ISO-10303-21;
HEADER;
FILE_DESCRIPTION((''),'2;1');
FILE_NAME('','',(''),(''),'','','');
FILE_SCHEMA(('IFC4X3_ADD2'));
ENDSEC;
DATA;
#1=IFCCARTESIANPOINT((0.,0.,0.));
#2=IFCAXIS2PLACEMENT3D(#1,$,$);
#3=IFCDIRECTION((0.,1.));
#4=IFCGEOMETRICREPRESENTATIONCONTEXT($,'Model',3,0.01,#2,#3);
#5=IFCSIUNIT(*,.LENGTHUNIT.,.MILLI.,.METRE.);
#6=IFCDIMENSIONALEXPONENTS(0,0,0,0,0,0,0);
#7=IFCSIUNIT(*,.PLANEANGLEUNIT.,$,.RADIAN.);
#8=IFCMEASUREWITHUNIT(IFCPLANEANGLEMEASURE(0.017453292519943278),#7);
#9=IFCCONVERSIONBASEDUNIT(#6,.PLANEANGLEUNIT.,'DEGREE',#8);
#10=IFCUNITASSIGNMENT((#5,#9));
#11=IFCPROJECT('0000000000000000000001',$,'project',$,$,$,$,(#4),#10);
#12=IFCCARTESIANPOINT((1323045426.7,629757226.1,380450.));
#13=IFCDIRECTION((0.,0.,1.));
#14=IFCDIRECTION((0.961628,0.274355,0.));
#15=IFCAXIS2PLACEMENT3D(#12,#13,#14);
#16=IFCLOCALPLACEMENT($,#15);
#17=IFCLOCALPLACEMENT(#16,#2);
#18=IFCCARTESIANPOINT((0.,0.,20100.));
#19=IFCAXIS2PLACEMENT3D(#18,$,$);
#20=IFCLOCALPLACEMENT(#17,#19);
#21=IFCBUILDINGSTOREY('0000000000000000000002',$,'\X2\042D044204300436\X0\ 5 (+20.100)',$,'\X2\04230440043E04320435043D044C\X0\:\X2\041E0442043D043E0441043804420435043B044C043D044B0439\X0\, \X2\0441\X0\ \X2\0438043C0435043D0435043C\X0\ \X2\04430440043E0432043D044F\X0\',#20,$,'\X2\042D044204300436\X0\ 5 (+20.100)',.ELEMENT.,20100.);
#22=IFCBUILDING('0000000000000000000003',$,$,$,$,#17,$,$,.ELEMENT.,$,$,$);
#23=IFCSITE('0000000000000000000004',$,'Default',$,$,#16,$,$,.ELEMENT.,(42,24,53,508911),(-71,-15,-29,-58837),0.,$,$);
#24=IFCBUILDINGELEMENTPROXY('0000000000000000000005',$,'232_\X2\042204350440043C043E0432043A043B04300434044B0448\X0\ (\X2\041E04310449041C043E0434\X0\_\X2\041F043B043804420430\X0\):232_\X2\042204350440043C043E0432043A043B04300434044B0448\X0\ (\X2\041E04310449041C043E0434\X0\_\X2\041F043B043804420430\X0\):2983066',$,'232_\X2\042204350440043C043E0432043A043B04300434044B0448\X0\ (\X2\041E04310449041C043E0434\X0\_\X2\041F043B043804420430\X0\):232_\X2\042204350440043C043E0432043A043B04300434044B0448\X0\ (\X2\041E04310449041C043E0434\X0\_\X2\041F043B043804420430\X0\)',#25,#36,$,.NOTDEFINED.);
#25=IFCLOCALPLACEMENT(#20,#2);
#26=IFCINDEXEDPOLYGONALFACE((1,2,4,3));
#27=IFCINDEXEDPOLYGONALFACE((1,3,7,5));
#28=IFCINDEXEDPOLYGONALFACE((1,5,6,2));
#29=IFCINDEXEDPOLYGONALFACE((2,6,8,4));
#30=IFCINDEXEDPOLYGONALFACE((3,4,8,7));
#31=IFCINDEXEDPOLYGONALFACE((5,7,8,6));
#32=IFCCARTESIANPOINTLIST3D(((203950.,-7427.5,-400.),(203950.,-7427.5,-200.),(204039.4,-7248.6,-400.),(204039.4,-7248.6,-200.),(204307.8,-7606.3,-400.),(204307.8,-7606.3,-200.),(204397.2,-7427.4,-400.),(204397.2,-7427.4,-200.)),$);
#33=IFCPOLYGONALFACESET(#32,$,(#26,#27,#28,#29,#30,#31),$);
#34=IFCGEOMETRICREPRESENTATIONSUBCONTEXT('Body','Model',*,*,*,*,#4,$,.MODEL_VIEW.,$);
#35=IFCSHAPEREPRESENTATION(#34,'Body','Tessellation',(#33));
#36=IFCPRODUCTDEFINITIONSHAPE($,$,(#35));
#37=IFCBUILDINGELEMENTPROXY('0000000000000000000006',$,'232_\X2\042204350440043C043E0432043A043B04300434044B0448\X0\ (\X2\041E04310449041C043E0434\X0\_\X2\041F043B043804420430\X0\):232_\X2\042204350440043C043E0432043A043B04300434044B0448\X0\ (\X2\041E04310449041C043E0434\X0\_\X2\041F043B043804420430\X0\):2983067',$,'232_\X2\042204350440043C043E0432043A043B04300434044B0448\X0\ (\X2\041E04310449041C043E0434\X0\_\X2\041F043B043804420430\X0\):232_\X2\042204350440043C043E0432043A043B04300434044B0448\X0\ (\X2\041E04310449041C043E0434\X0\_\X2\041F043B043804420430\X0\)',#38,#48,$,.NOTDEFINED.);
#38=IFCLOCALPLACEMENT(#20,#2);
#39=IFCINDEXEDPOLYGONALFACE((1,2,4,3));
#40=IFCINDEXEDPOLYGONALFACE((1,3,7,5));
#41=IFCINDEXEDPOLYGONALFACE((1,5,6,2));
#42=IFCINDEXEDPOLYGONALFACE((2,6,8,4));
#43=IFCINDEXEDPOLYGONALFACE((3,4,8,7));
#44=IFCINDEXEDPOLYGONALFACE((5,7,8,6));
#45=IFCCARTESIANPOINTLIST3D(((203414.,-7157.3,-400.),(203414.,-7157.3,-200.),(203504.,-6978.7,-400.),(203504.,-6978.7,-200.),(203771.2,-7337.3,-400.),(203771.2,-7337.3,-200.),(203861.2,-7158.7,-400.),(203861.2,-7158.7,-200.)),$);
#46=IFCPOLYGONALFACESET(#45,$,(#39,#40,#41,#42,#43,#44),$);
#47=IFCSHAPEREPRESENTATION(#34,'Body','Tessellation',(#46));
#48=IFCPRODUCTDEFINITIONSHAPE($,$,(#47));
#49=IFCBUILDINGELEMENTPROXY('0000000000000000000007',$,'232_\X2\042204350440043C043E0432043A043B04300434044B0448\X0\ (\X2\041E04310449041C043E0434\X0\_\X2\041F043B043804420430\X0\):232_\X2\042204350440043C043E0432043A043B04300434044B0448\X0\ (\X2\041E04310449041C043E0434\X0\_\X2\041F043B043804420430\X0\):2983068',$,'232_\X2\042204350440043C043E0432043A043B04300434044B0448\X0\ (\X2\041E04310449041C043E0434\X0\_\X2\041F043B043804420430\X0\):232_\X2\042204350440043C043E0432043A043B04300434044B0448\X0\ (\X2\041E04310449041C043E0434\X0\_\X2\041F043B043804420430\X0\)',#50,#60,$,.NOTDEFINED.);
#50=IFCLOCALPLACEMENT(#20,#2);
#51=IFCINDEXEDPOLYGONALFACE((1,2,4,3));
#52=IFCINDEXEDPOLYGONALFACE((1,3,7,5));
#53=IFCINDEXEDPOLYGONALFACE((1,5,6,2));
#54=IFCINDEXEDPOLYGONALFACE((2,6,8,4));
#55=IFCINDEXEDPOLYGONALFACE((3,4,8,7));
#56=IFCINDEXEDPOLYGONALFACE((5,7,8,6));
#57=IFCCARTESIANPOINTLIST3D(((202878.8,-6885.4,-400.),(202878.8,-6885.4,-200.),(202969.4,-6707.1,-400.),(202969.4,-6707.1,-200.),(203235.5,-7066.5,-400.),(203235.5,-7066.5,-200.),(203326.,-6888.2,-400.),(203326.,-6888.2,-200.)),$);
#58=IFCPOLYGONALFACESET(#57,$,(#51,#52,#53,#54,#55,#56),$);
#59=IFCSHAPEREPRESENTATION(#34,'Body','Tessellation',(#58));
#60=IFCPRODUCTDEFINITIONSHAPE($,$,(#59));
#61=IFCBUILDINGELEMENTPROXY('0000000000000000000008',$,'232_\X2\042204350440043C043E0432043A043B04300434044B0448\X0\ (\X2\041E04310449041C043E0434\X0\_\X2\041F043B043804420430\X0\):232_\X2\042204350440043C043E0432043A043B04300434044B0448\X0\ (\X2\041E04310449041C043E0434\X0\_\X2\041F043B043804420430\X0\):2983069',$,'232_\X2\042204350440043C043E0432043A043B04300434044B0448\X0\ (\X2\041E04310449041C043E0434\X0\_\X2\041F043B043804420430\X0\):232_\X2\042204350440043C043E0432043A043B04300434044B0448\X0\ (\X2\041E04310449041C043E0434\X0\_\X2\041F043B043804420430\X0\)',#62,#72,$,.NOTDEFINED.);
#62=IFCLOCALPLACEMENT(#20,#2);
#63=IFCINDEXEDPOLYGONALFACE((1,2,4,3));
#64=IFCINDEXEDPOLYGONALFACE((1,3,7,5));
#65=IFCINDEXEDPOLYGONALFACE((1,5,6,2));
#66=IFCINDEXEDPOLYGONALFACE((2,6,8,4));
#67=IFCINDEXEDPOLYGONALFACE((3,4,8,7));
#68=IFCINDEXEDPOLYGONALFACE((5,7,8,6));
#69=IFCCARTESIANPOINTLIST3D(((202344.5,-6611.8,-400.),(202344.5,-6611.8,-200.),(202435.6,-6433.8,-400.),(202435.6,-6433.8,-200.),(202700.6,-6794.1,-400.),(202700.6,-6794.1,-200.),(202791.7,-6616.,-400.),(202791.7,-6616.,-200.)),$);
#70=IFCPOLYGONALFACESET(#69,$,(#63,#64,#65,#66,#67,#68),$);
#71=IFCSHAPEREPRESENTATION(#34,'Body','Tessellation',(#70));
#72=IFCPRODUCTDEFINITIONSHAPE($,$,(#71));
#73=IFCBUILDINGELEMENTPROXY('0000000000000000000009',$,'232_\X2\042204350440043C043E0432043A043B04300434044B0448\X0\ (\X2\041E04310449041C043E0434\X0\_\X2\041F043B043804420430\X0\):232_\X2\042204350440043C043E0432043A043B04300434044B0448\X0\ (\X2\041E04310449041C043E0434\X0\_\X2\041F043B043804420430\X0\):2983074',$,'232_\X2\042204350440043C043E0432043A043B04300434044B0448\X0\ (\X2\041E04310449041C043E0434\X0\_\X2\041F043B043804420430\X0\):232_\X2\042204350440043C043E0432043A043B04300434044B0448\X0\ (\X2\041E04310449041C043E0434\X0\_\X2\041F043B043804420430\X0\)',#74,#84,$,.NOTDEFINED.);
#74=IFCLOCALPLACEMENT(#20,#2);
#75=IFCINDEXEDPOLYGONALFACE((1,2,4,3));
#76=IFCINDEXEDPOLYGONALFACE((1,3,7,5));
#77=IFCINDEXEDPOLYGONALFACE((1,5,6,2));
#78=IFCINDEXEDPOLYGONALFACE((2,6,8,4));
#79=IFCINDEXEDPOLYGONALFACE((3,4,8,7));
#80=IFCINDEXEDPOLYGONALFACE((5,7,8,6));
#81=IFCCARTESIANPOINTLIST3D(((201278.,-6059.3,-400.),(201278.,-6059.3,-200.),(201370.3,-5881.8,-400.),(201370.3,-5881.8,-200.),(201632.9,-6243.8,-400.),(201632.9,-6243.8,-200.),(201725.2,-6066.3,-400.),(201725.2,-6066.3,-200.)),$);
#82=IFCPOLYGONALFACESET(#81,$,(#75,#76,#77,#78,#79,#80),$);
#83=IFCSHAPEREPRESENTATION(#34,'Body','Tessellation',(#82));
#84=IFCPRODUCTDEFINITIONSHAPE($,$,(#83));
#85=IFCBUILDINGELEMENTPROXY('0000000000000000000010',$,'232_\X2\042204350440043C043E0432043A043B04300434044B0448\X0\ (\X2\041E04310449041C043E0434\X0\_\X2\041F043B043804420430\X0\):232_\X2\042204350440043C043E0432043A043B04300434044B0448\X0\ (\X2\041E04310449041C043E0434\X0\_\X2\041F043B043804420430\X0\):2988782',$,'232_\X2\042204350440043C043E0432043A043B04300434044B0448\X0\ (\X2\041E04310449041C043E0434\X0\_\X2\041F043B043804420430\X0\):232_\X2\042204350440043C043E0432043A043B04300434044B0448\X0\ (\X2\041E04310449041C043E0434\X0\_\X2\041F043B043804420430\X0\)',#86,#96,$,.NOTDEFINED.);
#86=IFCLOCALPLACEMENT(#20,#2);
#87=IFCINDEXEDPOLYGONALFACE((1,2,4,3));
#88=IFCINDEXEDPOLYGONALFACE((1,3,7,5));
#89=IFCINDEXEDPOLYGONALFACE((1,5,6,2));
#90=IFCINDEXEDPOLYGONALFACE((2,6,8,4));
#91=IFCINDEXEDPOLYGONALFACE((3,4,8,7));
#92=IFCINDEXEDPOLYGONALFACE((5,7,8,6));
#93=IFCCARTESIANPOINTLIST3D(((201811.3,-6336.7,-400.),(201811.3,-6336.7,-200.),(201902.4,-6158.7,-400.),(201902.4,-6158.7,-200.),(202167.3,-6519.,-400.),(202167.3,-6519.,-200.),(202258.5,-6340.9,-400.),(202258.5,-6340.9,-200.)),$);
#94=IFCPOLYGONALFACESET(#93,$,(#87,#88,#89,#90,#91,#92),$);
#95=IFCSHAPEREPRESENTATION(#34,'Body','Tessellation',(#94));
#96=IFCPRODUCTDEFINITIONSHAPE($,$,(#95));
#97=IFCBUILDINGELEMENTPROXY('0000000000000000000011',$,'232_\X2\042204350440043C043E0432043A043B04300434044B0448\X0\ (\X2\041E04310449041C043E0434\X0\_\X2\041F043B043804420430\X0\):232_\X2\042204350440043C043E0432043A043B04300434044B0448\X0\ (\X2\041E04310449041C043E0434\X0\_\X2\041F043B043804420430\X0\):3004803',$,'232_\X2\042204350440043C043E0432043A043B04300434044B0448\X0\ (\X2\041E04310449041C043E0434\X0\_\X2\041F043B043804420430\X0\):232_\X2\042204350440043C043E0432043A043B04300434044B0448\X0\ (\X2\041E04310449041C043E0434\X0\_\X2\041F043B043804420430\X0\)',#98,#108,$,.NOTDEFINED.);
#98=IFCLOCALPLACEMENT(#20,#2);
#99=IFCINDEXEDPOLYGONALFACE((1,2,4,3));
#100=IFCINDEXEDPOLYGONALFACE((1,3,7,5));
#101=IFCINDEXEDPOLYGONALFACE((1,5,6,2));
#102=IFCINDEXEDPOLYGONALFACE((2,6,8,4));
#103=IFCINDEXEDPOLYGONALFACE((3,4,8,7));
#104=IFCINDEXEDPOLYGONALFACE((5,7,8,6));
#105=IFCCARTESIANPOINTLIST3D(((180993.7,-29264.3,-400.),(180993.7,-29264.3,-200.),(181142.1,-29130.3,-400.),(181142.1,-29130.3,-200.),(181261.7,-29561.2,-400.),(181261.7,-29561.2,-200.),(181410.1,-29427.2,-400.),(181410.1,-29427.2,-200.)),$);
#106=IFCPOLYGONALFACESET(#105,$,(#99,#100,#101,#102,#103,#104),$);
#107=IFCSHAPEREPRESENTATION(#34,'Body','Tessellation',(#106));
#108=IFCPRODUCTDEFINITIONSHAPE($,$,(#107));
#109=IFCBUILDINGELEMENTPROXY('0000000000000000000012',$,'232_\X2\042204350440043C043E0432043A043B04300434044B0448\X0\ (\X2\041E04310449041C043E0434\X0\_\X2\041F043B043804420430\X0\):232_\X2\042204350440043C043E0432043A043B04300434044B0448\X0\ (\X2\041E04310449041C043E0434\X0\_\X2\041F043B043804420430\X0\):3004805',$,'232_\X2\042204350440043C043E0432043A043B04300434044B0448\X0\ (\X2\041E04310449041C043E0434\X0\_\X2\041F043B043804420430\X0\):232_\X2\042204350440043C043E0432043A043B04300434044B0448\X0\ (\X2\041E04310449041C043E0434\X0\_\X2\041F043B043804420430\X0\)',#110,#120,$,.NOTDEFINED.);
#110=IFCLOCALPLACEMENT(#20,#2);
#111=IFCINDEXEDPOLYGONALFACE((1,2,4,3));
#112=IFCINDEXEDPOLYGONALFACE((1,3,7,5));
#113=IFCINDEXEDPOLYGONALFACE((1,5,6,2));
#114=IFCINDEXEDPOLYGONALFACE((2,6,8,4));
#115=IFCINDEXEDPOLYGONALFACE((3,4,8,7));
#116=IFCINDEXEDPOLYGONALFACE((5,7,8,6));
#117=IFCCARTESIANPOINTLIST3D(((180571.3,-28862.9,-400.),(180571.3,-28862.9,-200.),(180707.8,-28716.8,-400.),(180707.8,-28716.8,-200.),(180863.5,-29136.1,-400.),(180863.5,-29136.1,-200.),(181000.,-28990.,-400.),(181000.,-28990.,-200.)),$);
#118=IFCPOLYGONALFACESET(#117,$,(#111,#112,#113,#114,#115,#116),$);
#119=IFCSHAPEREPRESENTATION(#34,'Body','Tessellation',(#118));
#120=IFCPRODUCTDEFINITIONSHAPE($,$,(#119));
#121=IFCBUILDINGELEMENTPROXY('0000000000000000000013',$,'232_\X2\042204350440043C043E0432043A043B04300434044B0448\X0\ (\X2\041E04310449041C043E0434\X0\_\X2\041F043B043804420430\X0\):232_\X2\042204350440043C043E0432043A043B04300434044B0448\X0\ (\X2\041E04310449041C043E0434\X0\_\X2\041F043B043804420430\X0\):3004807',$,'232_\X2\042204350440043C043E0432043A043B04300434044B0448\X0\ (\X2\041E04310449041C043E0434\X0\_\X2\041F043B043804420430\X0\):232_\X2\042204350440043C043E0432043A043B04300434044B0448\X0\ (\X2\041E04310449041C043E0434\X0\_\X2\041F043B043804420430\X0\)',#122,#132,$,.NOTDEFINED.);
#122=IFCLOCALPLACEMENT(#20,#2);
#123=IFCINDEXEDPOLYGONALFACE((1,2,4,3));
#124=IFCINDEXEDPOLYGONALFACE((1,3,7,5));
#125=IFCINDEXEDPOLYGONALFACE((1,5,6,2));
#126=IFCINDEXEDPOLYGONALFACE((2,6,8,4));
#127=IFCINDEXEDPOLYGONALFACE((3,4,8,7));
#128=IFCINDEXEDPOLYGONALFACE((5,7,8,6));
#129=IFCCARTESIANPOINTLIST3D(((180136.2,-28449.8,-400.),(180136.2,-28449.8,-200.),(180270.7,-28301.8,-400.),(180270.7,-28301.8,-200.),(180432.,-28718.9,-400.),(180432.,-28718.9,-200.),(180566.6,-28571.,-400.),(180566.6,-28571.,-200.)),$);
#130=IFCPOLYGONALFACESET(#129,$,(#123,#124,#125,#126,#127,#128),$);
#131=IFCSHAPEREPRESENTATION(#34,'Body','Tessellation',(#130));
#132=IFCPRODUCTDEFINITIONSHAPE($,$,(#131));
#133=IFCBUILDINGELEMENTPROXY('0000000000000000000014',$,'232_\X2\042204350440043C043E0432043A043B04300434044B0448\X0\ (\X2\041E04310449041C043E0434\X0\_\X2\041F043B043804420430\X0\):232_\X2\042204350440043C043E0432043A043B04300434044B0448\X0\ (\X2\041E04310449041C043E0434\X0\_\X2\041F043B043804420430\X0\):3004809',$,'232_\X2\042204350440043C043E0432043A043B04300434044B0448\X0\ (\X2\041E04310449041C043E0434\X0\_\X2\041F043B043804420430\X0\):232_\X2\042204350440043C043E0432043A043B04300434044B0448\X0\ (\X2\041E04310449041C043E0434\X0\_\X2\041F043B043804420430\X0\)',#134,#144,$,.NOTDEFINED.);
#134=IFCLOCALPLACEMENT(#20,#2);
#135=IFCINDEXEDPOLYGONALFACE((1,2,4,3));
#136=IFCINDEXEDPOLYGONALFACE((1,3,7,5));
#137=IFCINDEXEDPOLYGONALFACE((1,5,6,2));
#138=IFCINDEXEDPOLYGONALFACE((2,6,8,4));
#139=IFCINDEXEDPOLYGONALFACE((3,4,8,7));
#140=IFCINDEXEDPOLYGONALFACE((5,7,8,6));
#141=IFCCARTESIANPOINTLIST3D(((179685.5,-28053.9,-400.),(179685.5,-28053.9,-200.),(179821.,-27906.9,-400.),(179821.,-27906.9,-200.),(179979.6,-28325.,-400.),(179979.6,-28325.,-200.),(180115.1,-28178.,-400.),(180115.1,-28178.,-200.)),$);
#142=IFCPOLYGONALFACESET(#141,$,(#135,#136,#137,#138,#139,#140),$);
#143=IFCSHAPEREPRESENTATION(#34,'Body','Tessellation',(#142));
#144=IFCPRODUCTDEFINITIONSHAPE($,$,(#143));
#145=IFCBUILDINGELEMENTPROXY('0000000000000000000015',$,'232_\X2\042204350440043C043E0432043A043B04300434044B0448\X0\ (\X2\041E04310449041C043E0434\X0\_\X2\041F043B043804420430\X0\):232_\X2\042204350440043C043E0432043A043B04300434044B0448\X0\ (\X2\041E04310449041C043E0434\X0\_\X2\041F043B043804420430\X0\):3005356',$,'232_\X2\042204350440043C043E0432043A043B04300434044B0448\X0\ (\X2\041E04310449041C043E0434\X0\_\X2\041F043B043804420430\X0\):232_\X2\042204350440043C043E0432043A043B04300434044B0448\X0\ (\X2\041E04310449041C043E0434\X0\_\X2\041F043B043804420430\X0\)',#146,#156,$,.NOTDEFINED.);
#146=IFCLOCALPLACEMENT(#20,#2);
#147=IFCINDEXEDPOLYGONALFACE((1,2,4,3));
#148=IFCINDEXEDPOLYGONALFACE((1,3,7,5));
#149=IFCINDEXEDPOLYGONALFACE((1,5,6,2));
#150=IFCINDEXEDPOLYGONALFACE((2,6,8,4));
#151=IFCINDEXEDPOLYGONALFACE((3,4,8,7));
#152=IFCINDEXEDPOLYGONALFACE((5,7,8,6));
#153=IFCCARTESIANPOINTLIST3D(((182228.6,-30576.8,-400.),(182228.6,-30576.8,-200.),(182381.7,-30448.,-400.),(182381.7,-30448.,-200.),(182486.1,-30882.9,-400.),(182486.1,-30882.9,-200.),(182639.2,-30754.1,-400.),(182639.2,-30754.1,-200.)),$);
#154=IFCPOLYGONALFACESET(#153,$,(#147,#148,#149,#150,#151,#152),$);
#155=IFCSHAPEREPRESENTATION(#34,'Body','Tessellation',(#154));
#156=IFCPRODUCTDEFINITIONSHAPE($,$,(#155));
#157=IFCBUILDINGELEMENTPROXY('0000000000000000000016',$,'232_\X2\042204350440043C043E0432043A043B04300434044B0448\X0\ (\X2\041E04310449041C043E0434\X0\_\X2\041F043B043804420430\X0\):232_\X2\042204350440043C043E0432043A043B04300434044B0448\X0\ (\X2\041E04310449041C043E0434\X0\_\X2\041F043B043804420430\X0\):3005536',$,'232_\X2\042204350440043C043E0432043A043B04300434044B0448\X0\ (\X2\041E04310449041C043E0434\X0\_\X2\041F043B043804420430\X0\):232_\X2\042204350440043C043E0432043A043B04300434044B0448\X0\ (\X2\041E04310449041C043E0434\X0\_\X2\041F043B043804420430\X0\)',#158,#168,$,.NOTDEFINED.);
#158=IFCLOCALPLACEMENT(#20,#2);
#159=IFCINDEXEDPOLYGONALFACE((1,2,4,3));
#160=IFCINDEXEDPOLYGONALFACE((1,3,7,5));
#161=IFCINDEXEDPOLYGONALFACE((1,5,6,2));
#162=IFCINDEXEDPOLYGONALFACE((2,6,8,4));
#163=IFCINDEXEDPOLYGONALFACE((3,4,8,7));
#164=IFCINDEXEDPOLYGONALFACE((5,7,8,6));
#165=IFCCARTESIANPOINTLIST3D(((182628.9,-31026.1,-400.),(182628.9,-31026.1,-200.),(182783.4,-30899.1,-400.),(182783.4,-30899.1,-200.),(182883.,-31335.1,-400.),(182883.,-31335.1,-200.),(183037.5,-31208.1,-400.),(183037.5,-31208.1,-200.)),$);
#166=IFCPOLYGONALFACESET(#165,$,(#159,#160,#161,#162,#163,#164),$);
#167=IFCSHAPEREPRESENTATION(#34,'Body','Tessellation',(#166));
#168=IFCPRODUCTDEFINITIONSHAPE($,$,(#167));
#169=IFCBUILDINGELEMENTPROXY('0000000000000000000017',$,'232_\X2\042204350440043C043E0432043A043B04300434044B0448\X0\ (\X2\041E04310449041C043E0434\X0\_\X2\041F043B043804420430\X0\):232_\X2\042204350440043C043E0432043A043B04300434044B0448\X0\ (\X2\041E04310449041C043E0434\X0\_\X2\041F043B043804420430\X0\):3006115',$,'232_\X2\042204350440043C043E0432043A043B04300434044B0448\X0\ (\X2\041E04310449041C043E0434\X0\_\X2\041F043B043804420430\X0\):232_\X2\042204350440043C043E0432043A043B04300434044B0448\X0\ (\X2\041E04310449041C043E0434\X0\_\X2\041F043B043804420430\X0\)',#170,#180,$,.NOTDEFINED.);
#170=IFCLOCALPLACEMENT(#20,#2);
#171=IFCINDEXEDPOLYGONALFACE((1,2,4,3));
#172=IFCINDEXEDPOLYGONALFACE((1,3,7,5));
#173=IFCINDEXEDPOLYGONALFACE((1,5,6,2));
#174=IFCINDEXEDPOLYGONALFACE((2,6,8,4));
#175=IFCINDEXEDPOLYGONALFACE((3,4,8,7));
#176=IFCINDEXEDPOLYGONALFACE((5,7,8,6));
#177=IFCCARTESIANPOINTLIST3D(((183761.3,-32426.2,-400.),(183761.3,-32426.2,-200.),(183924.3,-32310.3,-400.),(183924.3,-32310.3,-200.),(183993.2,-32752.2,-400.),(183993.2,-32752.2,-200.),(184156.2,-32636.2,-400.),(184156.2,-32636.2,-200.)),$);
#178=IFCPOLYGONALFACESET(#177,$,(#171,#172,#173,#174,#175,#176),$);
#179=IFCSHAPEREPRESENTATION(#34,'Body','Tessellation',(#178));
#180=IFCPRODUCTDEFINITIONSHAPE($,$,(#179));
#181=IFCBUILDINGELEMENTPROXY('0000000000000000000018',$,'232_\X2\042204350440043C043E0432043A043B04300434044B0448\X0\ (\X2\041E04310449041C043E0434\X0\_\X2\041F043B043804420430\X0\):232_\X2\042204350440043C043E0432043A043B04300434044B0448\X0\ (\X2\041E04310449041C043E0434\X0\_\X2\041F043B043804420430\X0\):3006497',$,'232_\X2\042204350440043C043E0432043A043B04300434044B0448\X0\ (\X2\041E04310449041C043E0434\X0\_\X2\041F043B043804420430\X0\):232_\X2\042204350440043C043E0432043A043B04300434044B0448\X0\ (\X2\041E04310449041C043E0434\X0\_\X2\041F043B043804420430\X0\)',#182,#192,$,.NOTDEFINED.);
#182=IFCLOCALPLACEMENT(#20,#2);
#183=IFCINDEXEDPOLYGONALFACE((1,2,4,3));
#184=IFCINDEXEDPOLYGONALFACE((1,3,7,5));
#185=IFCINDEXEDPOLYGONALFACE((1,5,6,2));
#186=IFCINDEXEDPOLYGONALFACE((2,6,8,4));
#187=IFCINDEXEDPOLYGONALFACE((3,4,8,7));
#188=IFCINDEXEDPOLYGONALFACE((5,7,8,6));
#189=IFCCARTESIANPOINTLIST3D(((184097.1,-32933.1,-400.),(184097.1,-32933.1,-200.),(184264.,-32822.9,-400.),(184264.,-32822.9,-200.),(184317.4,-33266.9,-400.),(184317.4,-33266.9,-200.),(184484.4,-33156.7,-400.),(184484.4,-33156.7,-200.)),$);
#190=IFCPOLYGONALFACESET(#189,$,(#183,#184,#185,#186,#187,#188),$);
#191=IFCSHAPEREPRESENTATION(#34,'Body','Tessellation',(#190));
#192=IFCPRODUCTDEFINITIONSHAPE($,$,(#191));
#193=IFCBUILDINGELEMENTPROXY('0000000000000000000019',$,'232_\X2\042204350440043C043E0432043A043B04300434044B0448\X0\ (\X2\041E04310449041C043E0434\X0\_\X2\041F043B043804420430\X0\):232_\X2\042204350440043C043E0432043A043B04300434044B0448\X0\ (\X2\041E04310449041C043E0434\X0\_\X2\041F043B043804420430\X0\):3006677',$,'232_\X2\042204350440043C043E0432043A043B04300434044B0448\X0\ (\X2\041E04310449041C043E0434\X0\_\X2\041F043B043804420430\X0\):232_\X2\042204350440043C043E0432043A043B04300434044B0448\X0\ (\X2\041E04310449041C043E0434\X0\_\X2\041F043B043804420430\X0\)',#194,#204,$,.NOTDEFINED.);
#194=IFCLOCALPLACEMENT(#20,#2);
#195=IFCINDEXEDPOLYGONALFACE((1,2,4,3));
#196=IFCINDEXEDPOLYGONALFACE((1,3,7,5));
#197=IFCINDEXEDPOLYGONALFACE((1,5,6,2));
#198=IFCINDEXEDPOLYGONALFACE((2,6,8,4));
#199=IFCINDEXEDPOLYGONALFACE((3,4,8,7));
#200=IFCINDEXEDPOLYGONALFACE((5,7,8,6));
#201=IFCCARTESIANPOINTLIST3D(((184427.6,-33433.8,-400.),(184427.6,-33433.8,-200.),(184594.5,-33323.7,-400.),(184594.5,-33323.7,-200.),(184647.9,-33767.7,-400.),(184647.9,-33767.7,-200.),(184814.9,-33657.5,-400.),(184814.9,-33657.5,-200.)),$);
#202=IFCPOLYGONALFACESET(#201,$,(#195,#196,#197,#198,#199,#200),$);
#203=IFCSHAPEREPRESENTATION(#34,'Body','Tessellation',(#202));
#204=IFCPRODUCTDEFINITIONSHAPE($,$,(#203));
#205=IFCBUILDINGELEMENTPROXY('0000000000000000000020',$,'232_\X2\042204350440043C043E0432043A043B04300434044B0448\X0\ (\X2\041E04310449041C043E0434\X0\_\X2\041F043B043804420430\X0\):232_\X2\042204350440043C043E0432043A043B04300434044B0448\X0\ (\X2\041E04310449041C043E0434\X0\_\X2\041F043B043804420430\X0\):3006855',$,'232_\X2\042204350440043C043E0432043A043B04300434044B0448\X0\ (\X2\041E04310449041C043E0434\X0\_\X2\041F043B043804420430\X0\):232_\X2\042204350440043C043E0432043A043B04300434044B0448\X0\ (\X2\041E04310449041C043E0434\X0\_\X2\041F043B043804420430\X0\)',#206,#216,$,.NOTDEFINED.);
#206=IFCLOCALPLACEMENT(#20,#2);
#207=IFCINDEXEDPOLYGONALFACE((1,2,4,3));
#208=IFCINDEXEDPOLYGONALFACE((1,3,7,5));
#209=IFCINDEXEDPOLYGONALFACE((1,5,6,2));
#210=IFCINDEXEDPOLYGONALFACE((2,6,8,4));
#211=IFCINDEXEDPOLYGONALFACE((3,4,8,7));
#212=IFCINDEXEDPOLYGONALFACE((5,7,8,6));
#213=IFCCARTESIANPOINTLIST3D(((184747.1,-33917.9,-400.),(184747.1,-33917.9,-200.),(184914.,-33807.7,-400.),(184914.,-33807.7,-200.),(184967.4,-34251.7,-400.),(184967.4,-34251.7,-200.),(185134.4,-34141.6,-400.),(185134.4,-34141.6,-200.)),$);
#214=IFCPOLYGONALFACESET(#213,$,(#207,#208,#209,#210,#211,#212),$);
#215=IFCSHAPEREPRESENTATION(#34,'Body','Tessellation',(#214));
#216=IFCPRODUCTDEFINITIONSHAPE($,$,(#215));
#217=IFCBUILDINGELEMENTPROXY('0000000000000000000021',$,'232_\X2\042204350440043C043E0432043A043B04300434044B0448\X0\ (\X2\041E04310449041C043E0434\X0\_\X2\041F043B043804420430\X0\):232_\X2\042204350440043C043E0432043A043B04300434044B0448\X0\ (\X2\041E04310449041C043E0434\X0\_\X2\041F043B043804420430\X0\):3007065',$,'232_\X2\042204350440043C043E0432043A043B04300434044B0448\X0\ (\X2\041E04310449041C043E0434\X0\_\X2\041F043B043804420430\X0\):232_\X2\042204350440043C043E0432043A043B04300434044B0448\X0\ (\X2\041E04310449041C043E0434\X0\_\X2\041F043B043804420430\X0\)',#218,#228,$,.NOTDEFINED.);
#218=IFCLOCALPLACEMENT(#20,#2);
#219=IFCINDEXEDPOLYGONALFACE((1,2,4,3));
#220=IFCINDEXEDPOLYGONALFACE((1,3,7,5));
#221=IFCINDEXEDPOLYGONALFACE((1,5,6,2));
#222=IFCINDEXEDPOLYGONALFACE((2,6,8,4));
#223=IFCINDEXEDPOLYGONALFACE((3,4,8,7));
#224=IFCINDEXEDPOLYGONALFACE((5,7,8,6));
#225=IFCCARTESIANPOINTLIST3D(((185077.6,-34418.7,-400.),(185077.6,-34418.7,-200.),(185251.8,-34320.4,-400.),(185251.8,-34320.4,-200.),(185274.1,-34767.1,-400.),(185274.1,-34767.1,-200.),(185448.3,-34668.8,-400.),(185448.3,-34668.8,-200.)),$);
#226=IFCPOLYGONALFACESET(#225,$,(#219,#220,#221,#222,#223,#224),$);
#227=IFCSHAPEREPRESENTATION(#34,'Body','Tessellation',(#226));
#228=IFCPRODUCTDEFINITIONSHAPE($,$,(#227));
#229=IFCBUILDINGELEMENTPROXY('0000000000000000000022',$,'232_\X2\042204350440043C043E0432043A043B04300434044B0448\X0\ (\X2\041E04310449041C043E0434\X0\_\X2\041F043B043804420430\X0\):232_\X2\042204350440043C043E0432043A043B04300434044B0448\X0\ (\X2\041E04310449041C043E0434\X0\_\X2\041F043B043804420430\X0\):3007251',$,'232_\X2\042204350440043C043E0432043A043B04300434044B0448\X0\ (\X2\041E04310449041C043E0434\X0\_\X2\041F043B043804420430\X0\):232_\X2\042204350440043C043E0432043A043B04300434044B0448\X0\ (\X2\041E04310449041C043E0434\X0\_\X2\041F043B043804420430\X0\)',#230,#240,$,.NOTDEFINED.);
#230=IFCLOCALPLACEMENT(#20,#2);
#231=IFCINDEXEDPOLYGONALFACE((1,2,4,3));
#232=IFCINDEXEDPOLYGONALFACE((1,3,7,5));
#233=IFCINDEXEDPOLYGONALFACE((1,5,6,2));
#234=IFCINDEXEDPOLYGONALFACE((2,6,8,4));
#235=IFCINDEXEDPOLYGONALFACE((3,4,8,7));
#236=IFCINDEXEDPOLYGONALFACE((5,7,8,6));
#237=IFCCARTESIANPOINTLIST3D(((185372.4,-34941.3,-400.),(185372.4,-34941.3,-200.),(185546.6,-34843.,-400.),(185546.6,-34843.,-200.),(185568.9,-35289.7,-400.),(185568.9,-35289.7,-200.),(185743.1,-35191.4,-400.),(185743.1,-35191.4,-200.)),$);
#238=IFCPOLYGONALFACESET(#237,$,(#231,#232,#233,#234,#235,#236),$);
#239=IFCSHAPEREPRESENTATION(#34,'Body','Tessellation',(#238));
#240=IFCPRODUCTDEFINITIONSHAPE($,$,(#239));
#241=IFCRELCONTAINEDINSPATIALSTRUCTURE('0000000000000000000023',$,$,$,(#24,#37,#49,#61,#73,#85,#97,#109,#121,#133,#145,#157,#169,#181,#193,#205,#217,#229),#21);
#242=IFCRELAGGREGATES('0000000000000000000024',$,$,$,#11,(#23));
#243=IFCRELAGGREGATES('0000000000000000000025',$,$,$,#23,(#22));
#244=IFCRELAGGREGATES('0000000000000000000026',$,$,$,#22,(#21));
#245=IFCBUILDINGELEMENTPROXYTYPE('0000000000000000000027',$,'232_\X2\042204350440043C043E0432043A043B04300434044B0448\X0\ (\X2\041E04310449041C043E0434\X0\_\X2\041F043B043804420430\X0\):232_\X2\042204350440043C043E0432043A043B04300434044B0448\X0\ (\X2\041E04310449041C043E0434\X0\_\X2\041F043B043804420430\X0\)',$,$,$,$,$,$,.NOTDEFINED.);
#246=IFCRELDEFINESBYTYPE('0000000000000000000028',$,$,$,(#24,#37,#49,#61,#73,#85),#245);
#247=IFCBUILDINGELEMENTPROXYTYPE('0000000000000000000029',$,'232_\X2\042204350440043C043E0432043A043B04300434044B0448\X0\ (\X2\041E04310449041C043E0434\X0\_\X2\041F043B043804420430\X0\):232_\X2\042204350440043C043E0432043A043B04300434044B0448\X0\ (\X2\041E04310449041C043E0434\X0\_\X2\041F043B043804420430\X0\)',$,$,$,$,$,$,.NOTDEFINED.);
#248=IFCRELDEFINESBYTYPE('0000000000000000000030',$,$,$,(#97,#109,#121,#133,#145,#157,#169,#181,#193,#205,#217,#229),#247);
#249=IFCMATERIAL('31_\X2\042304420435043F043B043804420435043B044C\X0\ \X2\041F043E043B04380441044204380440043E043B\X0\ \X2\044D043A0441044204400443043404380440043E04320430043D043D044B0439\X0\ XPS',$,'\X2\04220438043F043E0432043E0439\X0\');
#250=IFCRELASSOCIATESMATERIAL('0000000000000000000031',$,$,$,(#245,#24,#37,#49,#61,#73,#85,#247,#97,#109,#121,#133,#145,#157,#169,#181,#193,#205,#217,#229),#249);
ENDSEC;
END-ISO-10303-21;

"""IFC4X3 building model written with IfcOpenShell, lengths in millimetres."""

from ifc_helpers import new_model, entity, si_unit, converted_unit, direction, frame, origin, origin_2d_with_axis, place, context, subcontext, project, spatial, rectangle, extrude, source, transform, mapped, material, type_object, type_shapes, element, save


model = new_model("IFC4X3")

# Units and contexts
model_context = context("Model", 3, precision=0.01, world=origin(), true_north=direction((0.0, 1.0)))
body_context = subcontext(model_context, "Body", "Model", "MODEL_VIEW")
ifc_project = project(units=[si_unit("LENGTHUNIT", "METRE", prefix="MILLI"), converted_unit("PLANEANGLEUNIT", "DEGREE", entity("IfcPlaneAngleMeasure", 0.017453292519943278), si_unit("PLANEANGLEUNIT", "RADIAN"), dimensions=[0, 0, 0, 0, 0, 0, 0])], contexts=[model_context])

# Site, building, storey
site_placement = place(None, frame((1323045426.7, 629757226.1, 380450.0), z_axis=(0.0, 0.0, 1.0), x_axis=(0.961628, 0.274355, 0.0)))
site = spatial("IfcSite", under=ifc_project, at=site_placement, Name="Default", CompositionType="ELEMENT", RefLatitude=(42, 24, 53, 508911), RefLongitude=(-71, -15, -29, -58837), RefElevation=0.0)
building_placement = place(site_placement, origin())
building = spatial("IfcBuilding", under=site, at=building_placement, CompositionType="ELEMENT")
storey_placement = place(building_placement, frame((0.0, 0.0, 20100.0)))
storey = spatial("IfcBuildingStorey", under=building, at=storey_placement, Name="Этаж 5 (+20.100)", ObjectType="Уровень:Относительный, с именем уровня", LongName="Этаж 5 (+20.100)", CompositionType="ELEMENT", Elevation=20100.0)

# Building element proxies
ifc_material = material(Name="31_Утеплитель Полистирол экструдированный XPS", Category="Типовой")
building_element_proxy_type_1 = type_object("IfcBuildingElementProxyType", Name="232_Термовкладыш (ОбщМод_Плита):232_Термовкладыш (ОбщМод_Плита)", PredefinedType="NOTDEFINED", material=ifc_material)
shared_shape_1 = source(origin(), body_context, "Body", "SweptSolid", [
    extrude(rectangle(XDim=400.0, YDim=200.0, at=origin_2d_with_axis()), frame((200.0, 0.0, -200.0), z_axis=(0.0, 0.0, 1.0), x_axis=(-1.0, 0.0, 0.0)), (0.0, 0.0, 1.0), 200.0),
])
type_shapes(building_element_proxy_type_1, [shared_shape_1])
for number, where, z_axis, x_axis, name in (
    (1, (204352.5, -7516.9, -200.0), (0.0, 0.0, 1.0), (-0.894486, 0.447096, 0.0), "232_Термовкладыш (ОбщМод_Плита):232_Термовкладыш (ОбщМод_Плита):2983066"),
    (2, (203816.2, -7248.0, -200.0), (0.0, 0.0, 1.0), (-0.893056, 0.449945, 0.0), "232_Термовкладыш (ОбщМод_Плита):232_Термовкладыш (ОбщМод_Плита):2983067"),
    (3, (203280.7, -6977.4, -200.0), (0.0, 0.0, 1.0), (-0.891618, 0.452789, 0.0), "232_Термовкладыш (ОбщМод_Плита):232_Термовкладыш (ОбщМод_Плита):2983068"),
    (4, (202746.1, -6705.0, -200.0), (0.0, 0.0, 1.0), (-0.89017, 0.455629, 0.0), "232_Термовкладыш (ОбщМод_Плита):232_Термовкладыш (ОбщМод_Плита):2983069"),
    (5, (201679.1, -6155.1, -200.0), (0.0, 0.0, 1.0), (-0.887248, 0.461294, 0.0), "232_Термовкладыш (ОбщМод_Плита):232_Термовкладыш (ОбщМод_Плита):2983074"),
    (6, (202212.9, -6430.0, -200.0), (0.0, 0.0, 1.0), (-0.89017, 0.455629, 0.0), "232_Термовкладыш (ОбщМод_Плита):232_Термовкладыш (ОбщМод_Плита):2988782"),
):
    element("IfcBuildingElementProxy", number, at=place(storey_placement, frame(where, z_axis=z_axis, x_axis=x_axis)), inside=storey, type_object=building_element_proxy_type_1, material=ifc_material, Name=name, ObjectType="232_Термовкладыш (ОбщМод_Плита):232_Термовкладыш (ОбщМод_Плита)", PredefinedType="NOTDEFINED", context=body_context, shape_type="MappedRepresentation", body=[
        mapped(shared_shape_1, transform((0.0, 0.0, 0.0), scale=1.0)),
    ])
building_element_proxy_type_2 = type_object("IfcBuildingElementProxyType", Name="232_Термовкладыш (ОбщМод_Плита):232_Термовкладыш (ОбщМод_Плита)", PredefinedType="NOTDEFINED", material=ifc_material)
shared_shape_2 = source(origin(), body_context, "Body", "SweptSolid", [
    extrude(rectangle(XDim=200.0, YDim=400.0, at=origin_2d_with_axis()), frame((200.0, 0.0, -200.0), z_axis=(0.0, 0.0, 1.0), x_axis=(0.0, 1.0, 0.0)), (0.0, 0.0, 1.0), 200.0),
])
type_shapes(building_element_proxy_type_2, [shared_shape_2])
for number, where, z_axis, x_axis, name in (
    (7, (181335.9, -29494.2, -200.0), (0.0, 0.0, 1.0), (-0.67003, 0.742334, 0.0), "232_Термовкладыш (ОбщМод_Плита):232_Термовкладыш (ОбщМод_Плита):3004803"),
    (8, (180931.7, -29063.0, -200.0), (0.0, 0.0, 1.0), (-0.730486, 0.682927, 0.0), "232_Термовкладыш (ОбщМод_Плита):232_Термовкладыш (ОбщМод_Плита):3004805"),
    (9, (180499.3, -28645.0, -200.0), (0.0, 0.0, 1.0), (-0.739744, 0.672889, 0.0), "232_Термовкладыш (ОбщМод_Плита):232_Термовкладыш (ОбщМод_Плита):3004807"),
    (10, (180047.4, -28251.5, -200.0), (0.0, 0.0, 1.0), (-0.735295, 0.677747, 0.0), "232_Термовкладыш (ОбщМод_Плита):232_Термовкладыш (ОбщМод_Плита):3004809"),
    (11, (182562.6, -30818.5, -200.0), (0.0, 0.0, 1.0), (-0.643715, 0.765265, 0.0), "232_Термовкладыш (ОбщМод_Плита):232_Термовкладыш (ОбщМод_Плита):3005356"),
    (12, (182960.2, -31271.6, -200.0), (0.0, 0.0, 1.0), (-0.635066, 0.772458, 0.0), "232_Термовкладыш (ОбщМод_Плита):232_Термовкладыш (ОбщМод_Плита):3005536"),
    (13, (184074.7, -32694.2, -200.0), (0.0, 0.0, 1.0), (-0.579635, 0.814876, 0.0), "232_Термовкладыш (ОбщМод_Плита):232_Термовкладыш (ОбщМод_Плита):3006115"),
    (14, (184400.9, -33211.8, -200.0), (0.0, 0.0, 1.0), (-0.550843, 0.834609, 0.0), "232_Термовкладыш (ОбщМод_Плита):232_Термовкладыш (ОбщМод_Плита):3006497"),
    (15, (184731.4, -33712.6, -200.0), (0.0, 0.0, 1.0), (-0.550843, 0.834609, 0.0), "232_Термовкладыш (ОбщМод_Плита):232_Термовкладыш (ОбщМод_Плита):3006677"),
    (16, (185050.9, -34196.7, -200.0), (0.0, 0.0, 1.0), (-0.550843, 0.834609, 0.0), "232_Термовкладыш (ОбщМод_Плита):232_Термовкладыш (ОбщМод_Плита):3006855"),
    (17, (185361.2, -34717.9, -200.0), (0.0, 0.0, 1.0), (-0.491282, 0.871001, 0.0), "232_Термовкладыш (ОбщМод_Плита):232_Термовкладыш (ОбщМод_Плита):3007065"),
    (18, (185656.0, -35240.5, -200.0), (0.0, 0.0, 1.0), (-0.491282, 0.871001, 0.0), "232_Термовкладыш (ОбщМод_Плита):232_Термовкладыш (ОбщМод_Плита):3007251"),
):
    element("IfcBuildingElementProxy", number, at=place(storey_placement, frame(where, z_axis=z_axis, x_axis=x_axis)), inside=storey, type_object=building_element_proxy_type_2, material=ifc_material, Name=name, ObjectType="232_Термовкладыш (ОбщМод_Плита):232_Термовкладыш (ОбщМод_Плита)", PredefinedType="NOTDEFINED", context=body_context, shape_type="MappedRepresentation", body=[
        mapped(shared_shape_2, transform((0.0, 0.0, 0.0), scale=1.0)),
    ])

save(model, "model.ifc")
